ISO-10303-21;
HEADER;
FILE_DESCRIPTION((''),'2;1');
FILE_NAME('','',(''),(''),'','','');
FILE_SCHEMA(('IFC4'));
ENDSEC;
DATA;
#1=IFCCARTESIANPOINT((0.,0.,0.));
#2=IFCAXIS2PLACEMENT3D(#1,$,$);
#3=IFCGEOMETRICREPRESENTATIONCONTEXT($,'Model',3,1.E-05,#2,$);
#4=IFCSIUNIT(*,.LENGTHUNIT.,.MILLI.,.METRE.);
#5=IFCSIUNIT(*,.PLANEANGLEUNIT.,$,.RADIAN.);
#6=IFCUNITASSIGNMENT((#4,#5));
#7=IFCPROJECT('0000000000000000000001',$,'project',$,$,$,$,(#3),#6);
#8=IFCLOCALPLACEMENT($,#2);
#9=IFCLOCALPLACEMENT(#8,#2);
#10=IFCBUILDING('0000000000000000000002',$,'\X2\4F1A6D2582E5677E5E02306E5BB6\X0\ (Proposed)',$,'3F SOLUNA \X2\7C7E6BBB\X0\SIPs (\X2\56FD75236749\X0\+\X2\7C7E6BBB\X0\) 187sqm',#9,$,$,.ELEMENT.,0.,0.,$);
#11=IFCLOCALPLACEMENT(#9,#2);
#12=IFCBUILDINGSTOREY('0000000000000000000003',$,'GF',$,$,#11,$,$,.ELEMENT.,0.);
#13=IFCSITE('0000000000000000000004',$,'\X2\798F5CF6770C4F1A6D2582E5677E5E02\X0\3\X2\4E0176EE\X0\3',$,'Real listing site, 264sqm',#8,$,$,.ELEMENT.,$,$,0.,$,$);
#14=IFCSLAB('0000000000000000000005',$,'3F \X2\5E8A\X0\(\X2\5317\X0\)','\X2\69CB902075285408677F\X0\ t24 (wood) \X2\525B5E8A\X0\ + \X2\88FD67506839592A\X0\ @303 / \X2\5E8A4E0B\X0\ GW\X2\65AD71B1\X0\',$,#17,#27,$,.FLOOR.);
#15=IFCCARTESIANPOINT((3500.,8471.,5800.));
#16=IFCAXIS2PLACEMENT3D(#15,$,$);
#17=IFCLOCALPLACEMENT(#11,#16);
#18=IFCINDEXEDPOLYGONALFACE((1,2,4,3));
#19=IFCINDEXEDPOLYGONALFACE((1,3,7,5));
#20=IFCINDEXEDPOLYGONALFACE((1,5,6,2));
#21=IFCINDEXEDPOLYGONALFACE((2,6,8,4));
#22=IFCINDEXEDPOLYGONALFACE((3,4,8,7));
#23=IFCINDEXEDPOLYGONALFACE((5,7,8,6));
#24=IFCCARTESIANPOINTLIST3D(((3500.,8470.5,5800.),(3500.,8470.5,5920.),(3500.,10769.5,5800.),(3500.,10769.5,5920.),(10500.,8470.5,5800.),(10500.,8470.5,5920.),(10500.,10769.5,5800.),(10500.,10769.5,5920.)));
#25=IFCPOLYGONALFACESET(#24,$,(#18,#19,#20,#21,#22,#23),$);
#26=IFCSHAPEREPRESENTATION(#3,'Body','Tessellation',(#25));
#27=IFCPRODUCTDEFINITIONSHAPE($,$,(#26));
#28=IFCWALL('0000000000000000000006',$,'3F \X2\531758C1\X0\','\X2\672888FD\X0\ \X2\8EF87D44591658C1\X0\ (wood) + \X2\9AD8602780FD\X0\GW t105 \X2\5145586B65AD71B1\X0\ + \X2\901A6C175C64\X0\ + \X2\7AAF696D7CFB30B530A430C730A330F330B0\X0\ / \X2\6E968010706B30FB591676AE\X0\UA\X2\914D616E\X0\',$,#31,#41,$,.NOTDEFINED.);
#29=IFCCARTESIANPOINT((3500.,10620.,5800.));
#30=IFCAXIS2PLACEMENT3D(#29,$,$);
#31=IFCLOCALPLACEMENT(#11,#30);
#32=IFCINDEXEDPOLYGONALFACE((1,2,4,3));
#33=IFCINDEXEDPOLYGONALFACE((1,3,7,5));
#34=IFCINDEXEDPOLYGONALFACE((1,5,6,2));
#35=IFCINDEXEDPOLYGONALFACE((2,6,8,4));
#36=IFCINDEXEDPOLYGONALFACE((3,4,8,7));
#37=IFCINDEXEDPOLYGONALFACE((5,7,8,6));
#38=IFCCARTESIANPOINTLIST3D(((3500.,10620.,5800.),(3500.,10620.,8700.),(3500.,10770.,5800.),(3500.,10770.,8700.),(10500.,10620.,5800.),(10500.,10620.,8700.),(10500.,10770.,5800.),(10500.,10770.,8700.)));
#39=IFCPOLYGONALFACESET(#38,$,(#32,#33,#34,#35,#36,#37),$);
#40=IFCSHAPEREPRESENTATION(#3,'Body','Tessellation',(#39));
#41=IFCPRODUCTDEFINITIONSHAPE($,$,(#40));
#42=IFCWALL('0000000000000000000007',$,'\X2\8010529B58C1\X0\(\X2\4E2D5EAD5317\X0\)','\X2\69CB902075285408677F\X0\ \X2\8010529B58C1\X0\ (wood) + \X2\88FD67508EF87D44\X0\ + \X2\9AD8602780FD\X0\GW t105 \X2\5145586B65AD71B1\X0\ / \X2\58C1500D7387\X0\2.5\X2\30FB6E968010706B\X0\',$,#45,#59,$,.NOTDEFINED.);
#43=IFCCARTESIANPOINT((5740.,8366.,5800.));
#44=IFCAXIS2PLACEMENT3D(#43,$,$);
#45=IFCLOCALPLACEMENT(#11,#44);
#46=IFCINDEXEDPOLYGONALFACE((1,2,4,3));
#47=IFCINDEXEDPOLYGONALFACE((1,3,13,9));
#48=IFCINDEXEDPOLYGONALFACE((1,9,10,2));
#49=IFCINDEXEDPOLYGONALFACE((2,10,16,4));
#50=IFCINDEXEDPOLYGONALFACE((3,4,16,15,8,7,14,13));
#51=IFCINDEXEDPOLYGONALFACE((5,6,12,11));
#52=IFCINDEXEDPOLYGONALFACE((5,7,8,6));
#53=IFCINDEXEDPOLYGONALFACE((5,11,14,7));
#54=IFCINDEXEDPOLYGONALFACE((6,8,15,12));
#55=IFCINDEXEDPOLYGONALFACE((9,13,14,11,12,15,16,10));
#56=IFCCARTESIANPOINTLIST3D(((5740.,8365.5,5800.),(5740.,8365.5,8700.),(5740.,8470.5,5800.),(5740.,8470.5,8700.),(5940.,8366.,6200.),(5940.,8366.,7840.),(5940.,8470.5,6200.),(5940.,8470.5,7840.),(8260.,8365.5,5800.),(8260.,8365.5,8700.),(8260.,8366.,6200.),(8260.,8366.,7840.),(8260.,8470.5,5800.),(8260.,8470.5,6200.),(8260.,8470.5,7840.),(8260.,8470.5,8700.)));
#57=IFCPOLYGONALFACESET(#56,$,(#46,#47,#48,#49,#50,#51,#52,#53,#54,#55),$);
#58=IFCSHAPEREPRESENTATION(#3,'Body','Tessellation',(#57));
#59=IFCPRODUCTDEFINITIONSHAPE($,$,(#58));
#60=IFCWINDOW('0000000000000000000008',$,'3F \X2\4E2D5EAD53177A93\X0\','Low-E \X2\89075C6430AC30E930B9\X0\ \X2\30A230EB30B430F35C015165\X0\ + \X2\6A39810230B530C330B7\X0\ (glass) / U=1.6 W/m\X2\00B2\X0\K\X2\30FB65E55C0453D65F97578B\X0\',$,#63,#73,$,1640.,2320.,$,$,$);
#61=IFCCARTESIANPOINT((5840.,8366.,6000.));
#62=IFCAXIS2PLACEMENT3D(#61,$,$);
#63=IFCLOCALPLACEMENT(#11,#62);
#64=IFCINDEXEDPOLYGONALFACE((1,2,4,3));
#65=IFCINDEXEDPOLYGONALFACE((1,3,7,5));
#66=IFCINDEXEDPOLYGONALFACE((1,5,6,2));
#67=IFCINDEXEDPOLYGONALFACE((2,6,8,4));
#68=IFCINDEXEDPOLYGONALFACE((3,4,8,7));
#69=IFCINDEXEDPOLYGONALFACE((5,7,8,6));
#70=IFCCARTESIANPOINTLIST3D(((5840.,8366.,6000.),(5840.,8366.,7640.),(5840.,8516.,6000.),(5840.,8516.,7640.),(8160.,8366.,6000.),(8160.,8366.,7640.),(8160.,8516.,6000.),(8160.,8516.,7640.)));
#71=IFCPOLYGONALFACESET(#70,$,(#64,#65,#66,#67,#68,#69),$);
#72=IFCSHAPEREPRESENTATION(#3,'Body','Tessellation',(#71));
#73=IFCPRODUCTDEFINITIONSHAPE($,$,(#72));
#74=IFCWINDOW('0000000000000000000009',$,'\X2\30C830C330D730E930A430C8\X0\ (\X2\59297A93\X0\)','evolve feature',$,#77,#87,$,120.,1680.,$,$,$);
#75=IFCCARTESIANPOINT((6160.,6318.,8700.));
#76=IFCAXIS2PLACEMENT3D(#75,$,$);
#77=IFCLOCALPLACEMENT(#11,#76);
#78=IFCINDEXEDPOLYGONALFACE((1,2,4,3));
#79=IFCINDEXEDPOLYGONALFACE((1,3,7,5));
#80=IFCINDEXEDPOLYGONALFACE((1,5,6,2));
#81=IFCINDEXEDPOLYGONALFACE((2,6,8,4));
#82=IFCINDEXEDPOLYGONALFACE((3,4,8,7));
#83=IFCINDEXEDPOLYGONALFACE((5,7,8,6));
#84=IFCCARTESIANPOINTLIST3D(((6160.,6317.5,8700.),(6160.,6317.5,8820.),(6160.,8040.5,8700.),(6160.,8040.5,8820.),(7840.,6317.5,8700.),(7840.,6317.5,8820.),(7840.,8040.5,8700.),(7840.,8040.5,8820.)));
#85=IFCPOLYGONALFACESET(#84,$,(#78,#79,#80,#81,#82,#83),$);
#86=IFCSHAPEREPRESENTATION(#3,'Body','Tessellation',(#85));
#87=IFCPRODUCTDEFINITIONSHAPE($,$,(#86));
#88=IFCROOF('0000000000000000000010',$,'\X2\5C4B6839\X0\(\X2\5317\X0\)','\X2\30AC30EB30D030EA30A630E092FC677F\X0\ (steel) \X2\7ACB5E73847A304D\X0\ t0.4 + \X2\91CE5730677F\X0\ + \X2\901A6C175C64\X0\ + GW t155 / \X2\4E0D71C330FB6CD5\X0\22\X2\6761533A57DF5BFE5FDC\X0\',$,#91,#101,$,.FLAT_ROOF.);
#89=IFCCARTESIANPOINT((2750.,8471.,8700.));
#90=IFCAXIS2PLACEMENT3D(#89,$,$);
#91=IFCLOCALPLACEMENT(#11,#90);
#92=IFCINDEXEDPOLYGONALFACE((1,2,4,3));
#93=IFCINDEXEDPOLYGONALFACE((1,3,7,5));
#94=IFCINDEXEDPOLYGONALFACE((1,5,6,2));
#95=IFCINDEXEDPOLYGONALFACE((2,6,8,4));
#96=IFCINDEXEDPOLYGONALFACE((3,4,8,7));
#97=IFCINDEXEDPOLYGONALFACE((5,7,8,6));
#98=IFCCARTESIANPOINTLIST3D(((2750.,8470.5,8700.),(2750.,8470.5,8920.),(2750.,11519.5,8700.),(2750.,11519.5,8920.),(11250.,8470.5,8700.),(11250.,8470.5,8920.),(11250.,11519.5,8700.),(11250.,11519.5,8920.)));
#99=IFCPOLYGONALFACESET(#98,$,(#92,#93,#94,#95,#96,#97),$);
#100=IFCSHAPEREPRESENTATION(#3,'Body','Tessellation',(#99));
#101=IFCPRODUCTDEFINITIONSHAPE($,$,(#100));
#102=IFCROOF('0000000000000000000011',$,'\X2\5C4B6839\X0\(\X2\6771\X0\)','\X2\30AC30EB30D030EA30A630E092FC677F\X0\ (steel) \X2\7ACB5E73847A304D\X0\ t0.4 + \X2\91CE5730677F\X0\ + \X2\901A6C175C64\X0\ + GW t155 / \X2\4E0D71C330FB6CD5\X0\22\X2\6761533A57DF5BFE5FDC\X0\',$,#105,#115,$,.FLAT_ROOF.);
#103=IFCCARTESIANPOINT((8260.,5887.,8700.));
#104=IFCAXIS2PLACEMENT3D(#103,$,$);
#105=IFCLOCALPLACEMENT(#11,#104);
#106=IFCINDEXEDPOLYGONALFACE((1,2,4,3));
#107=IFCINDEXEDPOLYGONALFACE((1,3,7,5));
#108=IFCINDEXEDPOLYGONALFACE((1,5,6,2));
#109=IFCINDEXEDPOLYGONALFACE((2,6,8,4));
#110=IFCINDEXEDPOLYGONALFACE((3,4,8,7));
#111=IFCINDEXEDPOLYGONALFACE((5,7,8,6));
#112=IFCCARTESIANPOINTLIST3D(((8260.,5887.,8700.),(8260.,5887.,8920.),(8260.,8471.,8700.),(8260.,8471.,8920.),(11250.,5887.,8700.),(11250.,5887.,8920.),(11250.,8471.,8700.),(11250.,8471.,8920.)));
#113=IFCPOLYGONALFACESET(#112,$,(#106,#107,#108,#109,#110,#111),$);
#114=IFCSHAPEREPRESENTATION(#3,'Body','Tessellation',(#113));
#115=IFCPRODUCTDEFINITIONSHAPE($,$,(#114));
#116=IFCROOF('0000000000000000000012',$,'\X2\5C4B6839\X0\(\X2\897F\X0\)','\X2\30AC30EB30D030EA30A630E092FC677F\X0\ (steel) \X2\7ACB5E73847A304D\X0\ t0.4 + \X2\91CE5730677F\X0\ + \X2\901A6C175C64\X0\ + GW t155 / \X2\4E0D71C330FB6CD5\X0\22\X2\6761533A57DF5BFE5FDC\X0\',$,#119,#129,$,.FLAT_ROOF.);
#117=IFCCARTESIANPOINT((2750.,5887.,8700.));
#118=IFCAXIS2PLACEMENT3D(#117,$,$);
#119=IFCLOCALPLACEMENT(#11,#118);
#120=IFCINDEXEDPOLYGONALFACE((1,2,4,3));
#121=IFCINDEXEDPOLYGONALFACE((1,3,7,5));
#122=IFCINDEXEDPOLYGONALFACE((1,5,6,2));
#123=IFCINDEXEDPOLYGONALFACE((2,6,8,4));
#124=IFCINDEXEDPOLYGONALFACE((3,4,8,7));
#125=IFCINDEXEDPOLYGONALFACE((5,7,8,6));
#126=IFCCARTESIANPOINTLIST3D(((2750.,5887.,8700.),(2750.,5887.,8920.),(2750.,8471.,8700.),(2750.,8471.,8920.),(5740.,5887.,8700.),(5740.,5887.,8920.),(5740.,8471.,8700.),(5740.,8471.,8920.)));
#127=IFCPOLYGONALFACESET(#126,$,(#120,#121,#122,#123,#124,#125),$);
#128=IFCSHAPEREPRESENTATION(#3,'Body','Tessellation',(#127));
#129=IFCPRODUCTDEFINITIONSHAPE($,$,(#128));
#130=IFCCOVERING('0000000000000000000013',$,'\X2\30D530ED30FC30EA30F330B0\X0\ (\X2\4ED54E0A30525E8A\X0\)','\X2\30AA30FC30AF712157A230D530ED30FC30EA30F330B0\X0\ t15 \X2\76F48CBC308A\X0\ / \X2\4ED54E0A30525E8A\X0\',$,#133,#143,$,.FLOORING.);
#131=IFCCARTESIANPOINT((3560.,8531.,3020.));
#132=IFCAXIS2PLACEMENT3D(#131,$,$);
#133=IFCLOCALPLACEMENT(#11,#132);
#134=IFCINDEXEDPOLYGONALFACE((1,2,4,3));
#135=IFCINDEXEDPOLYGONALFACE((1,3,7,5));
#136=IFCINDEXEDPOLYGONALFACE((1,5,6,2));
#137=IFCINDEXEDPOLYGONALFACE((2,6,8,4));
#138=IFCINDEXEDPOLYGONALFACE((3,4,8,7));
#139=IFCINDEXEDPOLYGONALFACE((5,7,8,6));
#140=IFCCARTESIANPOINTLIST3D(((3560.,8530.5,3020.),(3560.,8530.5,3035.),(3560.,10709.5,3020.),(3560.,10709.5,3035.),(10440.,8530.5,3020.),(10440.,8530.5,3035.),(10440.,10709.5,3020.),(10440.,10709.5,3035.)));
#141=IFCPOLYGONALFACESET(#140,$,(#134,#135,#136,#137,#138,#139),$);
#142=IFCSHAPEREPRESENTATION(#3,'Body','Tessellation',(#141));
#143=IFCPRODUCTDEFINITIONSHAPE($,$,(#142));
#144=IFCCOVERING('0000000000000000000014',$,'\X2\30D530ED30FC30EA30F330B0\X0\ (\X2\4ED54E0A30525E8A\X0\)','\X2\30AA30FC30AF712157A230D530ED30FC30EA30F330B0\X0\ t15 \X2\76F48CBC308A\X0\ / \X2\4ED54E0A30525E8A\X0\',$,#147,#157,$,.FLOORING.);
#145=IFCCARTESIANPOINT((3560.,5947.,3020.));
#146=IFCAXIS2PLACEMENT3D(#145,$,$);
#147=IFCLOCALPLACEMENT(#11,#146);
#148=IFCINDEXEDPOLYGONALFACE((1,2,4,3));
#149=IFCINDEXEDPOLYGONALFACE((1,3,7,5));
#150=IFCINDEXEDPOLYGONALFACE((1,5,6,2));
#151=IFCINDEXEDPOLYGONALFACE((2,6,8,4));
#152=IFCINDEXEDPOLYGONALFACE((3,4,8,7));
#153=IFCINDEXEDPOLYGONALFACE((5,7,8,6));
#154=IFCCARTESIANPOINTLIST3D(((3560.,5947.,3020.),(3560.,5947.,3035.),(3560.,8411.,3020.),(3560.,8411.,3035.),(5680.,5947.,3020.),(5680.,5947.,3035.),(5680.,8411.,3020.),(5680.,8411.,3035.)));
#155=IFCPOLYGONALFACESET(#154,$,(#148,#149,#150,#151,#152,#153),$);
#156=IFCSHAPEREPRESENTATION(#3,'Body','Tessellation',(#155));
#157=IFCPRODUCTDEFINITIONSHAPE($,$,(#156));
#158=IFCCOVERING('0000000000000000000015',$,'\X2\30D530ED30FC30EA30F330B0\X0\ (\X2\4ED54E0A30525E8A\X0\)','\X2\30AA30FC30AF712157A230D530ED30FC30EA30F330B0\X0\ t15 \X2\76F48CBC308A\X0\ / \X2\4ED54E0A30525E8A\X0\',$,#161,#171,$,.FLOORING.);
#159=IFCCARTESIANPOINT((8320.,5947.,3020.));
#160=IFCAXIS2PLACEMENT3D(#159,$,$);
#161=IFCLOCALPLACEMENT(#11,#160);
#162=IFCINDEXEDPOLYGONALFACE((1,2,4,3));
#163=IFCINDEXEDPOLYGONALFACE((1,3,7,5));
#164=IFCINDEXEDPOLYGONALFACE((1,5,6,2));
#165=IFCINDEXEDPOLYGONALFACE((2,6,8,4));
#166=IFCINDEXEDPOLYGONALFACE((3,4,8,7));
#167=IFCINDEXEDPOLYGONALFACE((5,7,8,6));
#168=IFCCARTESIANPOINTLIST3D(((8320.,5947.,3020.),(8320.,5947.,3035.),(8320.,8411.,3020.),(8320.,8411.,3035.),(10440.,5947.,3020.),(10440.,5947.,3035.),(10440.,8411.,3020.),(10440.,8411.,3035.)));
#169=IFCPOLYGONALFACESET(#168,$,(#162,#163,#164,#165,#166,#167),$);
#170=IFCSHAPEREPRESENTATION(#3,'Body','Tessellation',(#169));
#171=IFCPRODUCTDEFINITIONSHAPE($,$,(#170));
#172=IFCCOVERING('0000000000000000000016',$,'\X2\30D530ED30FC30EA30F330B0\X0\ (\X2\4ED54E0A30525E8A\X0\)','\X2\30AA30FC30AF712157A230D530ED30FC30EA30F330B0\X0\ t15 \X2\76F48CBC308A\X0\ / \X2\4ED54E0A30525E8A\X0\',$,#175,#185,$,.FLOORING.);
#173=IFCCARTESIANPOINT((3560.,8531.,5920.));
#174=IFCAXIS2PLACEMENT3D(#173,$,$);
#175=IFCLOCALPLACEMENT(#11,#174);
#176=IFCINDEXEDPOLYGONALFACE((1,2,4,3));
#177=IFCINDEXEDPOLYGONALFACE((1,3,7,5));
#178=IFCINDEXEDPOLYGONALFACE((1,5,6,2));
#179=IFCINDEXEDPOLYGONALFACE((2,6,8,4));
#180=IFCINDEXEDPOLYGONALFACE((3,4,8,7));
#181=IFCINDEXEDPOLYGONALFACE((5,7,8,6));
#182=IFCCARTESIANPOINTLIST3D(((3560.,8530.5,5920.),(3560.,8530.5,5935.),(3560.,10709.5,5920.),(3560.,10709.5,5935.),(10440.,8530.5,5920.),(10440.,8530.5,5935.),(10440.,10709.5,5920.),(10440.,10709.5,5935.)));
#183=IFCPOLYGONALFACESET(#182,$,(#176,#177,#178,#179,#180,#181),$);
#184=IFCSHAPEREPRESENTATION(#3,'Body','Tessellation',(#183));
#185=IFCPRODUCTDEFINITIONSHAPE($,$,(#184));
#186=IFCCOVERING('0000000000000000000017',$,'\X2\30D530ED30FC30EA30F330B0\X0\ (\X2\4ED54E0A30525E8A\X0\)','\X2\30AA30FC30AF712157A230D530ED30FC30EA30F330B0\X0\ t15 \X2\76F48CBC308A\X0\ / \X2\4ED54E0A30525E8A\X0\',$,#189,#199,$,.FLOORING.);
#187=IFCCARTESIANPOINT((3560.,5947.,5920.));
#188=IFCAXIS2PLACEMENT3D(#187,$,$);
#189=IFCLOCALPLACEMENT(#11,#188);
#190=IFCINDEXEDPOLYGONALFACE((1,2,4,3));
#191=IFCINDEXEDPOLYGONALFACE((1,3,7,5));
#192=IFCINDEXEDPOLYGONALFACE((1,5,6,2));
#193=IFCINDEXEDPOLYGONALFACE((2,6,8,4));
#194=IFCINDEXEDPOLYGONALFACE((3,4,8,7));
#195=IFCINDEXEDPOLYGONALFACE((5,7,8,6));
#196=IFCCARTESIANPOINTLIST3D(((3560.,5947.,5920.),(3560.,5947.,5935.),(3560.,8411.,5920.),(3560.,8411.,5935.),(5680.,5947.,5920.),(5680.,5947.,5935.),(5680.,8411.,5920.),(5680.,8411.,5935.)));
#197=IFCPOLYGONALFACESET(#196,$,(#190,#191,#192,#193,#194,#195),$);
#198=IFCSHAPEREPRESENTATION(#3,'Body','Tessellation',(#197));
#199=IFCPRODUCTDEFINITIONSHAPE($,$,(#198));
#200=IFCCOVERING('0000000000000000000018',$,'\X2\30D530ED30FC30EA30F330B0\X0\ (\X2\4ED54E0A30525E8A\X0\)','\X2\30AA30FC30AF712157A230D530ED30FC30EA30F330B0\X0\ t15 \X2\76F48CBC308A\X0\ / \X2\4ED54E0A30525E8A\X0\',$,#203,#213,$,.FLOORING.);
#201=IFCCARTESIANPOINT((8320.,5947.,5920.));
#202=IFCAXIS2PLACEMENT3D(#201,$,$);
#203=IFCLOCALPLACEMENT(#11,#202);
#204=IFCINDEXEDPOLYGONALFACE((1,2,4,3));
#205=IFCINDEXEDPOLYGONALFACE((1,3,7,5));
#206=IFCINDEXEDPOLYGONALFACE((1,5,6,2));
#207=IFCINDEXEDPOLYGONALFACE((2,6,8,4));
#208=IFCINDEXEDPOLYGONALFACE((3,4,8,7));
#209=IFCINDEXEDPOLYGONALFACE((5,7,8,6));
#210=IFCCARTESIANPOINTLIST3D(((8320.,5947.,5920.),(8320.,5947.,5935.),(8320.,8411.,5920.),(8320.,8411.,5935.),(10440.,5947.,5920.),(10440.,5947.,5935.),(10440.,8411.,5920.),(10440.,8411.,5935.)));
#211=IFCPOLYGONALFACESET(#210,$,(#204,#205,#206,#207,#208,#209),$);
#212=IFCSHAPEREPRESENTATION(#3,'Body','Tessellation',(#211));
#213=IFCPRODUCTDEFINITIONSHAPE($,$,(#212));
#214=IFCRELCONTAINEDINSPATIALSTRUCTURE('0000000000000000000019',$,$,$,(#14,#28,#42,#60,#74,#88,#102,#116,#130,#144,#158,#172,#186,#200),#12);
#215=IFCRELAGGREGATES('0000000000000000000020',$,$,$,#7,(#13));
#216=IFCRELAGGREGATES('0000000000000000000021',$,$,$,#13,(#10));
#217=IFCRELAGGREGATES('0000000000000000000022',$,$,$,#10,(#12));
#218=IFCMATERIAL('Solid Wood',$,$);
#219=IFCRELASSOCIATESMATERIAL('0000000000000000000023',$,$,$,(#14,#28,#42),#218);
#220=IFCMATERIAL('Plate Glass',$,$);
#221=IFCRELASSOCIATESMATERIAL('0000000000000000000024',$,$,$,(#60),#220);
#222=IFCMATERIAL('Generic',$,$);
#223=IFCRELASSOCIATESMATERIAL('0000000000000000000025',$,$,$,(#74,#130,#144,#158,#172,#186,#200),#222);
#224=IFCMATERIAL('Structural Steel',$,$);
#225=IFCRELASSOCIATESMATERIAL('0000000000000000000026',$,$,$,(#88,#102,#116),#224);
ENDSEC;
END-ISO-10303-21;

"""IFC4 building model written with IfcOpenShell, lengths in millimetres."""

from ifc_helpers import new_model, si_unit, frame, frame_2d, origin, place, context, project, spatial, rectangle, extrude, material, element, fill, save


model = new_model("IFC4")

# Units and contexts
model_context = context("Model", 3, precision=1e-05, world=origin())
ifc_project = project(units=[si_unit("LENGTHUNIT", "METRE", prefix="MILLI"), si_unit("PLANEANGLEUNIT", "RADIAN")], contexts=[model_context])

# Site, building, storey
site_placement = place(None, origin())
site = spatial("IfcSite", under=ifc_project, at=site_placement, Name="福島県会津若松市3丁目3", ObjectType="Real listing site, 264sqm", CompositionType="ELEMENT", RefElevation=0.0)
building_placement = place(site_placement, origin())
building = spatial("IfcBuilding", under=site, at=building_placement, Name="会津若松市の家 (Proposed)", ObjectType="3F SOLUNA 籾殻SIPs (国産杉+籾殻) 187sqm", CompositionType="ELEMENT", ElevationOfRefHeight=0.0, ElevationOfTerrain=0.0)
storey_placement = place(building_placement, origin())
storey = spatial("IfcBuildingStorey", under=building, at=storey_placement, Name="GF", CompositionType="ELEMENT", Elevation=0.0)

# Slab
ifc_material_1 = material(Name="Solid Wood")
slab_placement = place(storey_placement, frame((3500.0, 8471.0, 5800.0)))
element("IfcSlab", 1, at=slab_placement, inside=storey, material=ifc_material_1, Name="3F 床(北)", Description="構造用合板 t24 (wood) 剛床 + 製材根太 @303 / 床下 GW断熱", PredefinedType="FLOOR", context=model_context, shape_type="SweptSolid", body=[
    extrude(rectangle(XDim=7000.0, YDim=2299.0, at=frame_2d((3500.0, 1149.0))), frame((3500.0, 8471.0, 5800.0)), (0.0, 0.0, 1.0), 120.0),
])

# Wall
wall_1_placement = place(storey_placement, frame((3500.0, 10620.0, 5800.0)))
element("IfcWall", 2, at=wall_1_placement, inside=storey, material=ifc_material_1, Name="3F 北壁", Description="木製 軸組外壁 (wood) + 高性能GW t105 充填断熱 + 通気層 + 窯業系サイディング / 準耐火・外皮UA配慮", PredefinedType="NOTDEFINED", context=model_context, shape_type="SweptSolid", body=[
    extrude(rectangle(XDim=7000.0, YDim=150.0, at=frame_2d((3500.0, 75.0))), frame((3500.0, 10620.0, 5800.0)), (0.0, 0.0, 1.0), 2900.0),
])

# Wall, opening, window
wall_2_placement = place(storey_placement, frame((5740.0, 8366.0, 5800.0)))
wall_2 = element("IfcWall", 3, at=wall_2_placement, inside=storey, material=ifc_material_1, Name="耐力壁(中庭北)", Description="構造用合板 耐力壁 (wood) + 製材軸組 + 高性能GW t105 充填断熱 / 壁倍率2.5・準耐火", PredefinedType="NOTDEFINED", context=model_context, shape_type="SweptSolid", body=[
    extrude(rectangle(XDim=2520.0, YDim=105.0, at=frame_2d((1260.0, 52.0))), frame((5740.0, 8366.0, 5800.0)), (0.0, 0.0, 1.0), 2900.0),
])
opening_placement = place(storey_placement, frame((5840.0, 8366.0, 6000.0)))
opening = element("IfcOpeningElement", 4, at=opening_placement, cuts=wall_2, PredefinedType="NOTDEFINED", context=model_context, shape_type="SweptSolid", body=[
    extrude(rectangle(XDim=2320.0, YDim=150.0, at=frame_2d((1160.0, 75.0))), frame((5840.0, 8366.0, 6000.0)), (0.0, 0.0, 1.0), 1640.0),
])
ifc_material_2 = material(Name="Plate Glass")
window_1_placement = place(storey_placement, frame((5840.0, 8366.0, 6000.0)))
window_1 = element("IfcWindow", 5, at=window_1_placement, inside=storey, material=ifc_material_2, Name="3F 中庭北窓", Description="Low-E 複層ガラス アルゴン封入 + 樹脂サッシ (glass) / U=1.6 W/m²K・日射取得型", OverallHeight=1640.0, OverallWidth=2320.0, context=model_context, shape_type="SweptSolid", body=[
    extrude(rectangle(XDim=2320.0, YDim=150.0, at=frame_2d((1160.0, 75.0))), frame((5840.0, 8366.0, 6000.0)), (0.0, 0.0, 1.0), 1640.0),
])
fill(opening, window_1)

# Window
ifc_material_3 = material(Name="Generic")
window_2_placement = place(storey_placement, frame((6160.0, 6318.0, 8700.0)))
element("IfcWindow", 6, at=window_2_placement, inside=storey, material=ifc_material_3, Name="トップライト (天窓)", Description="evolve feature", OverallHeight=120.0, OverallWidth=1680.0, context=model_context, shape_type="SweptSolid", body=[
    extrude(rectangle(XDim=1680.0, YDim=1723.0, at=frame_2d((840.0, 861.0))), frame((6160.0, 6318.0, 8700.0)), (0.0, 0.0, 1.0), 120.0),
])

# Roofs
ifc_material_4 = material(Name="Structural Steel")
roof_1_placement = place(storey_placement, frame((2750.0, 8471.0, 8700.0)))
element("IfcRoof", 7, at=roof_1_placement, inside=storey, material=ifc_material_4, Name="屋根(北)", Description="ガルバリウム鋼板 (steel) 立平葺き t0.4 + 野地板 + 通気層 + GW t155 / 不燃・法22条区域対応", PredefinedType="FLAT_ROOF", context=model_context, shape_type="SweptSolid", body=[
    extrude(rectangle(XDim=8500.0, YDim=3049.0, at=frame_2d((4250.0, 1524.0))), frame((2750.0, 8471.0, 8700.0)), (0.0, 0.0, 1.0), 220.0),
])
roof_2_placement = place(storey_placement, frame((8260.0, 5887.0, 8700.0)))
element("IfcRoof", 8, at=roof_2_placement, inside=storey, material=ifc_material_4, Name="屋根(東)", Description="ガルバリウム鋼板 (steel) 立平葺き t0.4 + 野地板 + 通気層 + GW t155 / 不燃・法22条区域対応", PredefinedType="FLAT_ROOF", context=model_context, shape_type="SweptSolid", body=[
    extrude(rectangle(XDim=2990.0, YDim=2584.0, at=frame_2d((1495.0, 1292.0))), frame((8260.0, 5887.0, 8700.0)), (0.0, 0.0, 1.0), 220.0),
])
roof_3_placement = place(storey_placement, frame((2750.0, 5887.0, 8700.0)))
element("IfcRoof", 9, at=roof_3_placement, inside=storey, material=ifc_material_4, Name="屋根(西)", Description="ガルバリウム鋼板 (steel) 立平葺き t0.4 + 野地板 + 通気層 + GW t155 / 不燃・法22条区域対応", PredefinedType="FLAT_ROOF", context=model_context, shape_type="SweptSolid", body=[
    extrude(rectangle(XDim=2990.0, YDim=2584.0, at=frame_2d((1495.0, 1292.0))), frame((2750.0, 5887.0, 8700.0)), (0.0, 0.0, 1.0), 220.0),
])

# Coverings
covering_1_placement = place(storey_placement, frame((3560.0, 8531.0, 3020.0)))
element("IfcCovering", 10, at=covering_1_placement, inside=storey, material=ifc_material_3, Name="フローリング (仕上げ床)", Description="オーク無垢フローリング t15 直貼り / 仕上げ床", PredefinedType="FLOORING", context=model_context, shape_type="SweptSolid", body=[
    extrude(rectangle(XDim=6880.0, YDim=2179.0, at=frame_2d((3440.0, 1089.0))), frame((3560.0, 8531.0, 3020.0)), (0.0, 0.0, 1.0), 15.0),
])
covering_2_placement = place(storey_placement, frame((3560.0, 5947.0, 3020.0)))
element("IfcCovering", 11, at=covering_2_placement, inside=storey, material=ifc_material_3, Name="フローリング (仕上げ床)", Description="オーク無垢フローリング t15 直貼り / 仕上げ床", PredefinedType="FLOORING", context=model_context, shape_type="SweptSolid", body=[
    extrude(rectangle(XDim=2120.0, YDim=2464.0, at=frame_2d((1060.0, 1232.0))), frame((3560.0, 5947.0, 3020.0)), (0.0, 0.0, 1.0), 15.0),
])
covering_3_placement = place(storey_placement, frame((8320.0, 5947.0, 3020.0)))
element("IfcCovering", 12, at=covering_3_placement, inside=storey, material=ifc_material_3, Name="フローリング (仕上げ床)", Description="オーク無垢フローリング t15 直貼り / 仕上げ床", PredefinedType="FLOORING", context=model_context, shape_type="SweptSolid", body=[
    extrude(rectangle(XDim=2120.0, YDim=2464.0, at=frame_2d((1060.0, 1232.0))), frame((8320.0, 5947.0, 3020.0)), (0.0, 0.0, 1.0), 15.0),
])
covering_4_placement = place(storey_placement, frame((3560.0, 8531.0, 5920.0)))
element("IfcCovering", 13, at=covering_4_placement, inside=storey, material=ifc_material_3, Name="フローリング (仕上げ床)", Description="オーク無垢フローリング t15 直貼り / 仕上げ床", PredefinedType="FLOORING", context=model_context, shape_type="SweptSolid", body=[
    extrude(rectangle(XDim=6880.0, YDim=2179.0, at=frame_2d((3440.0, 1089.0))), frame((3560.0, 8531.0, 5920.0)), (0.0, 0.0, 1.0), 15.0),
])
covering_5_placement = place(storey_placement, frame((3560.0, 5947.0, 5920.0)))
element("IfcCovering", 14, at=covering_5_placement, inside=storey, material=ifc_material_3, Name="フローリング (仕上げ床)", Description="オーク無垢フローリング t15 直貼り / 仕上げ床", PredefinedType="FLOORING", context=model_context, shape_type="SweptSolid", body=[
    extrude(rectangle(XDim=2120.0, YDim=2464.0, at=frame_2d((1060.0, 1232.0))), frame((3560.0, 5947.0, 5920.0)), (0.0, 0.0, 1.0), 15.0),
])
covering_6_placement = place(storey_placement, frame((8320.0, 5947.0, 5920.0)))
element("IfcCovering", 15, at=covering_6_placement, inside=storey, material=ifc_material_3, Name="フローリング (仕上げ床)", Description="オーク無垢フローリング t15 直貼り / 仕上げ床", PredefinedType="FLOORING", context=model_context, shape_type="SweptSolid", body=[
    extrude(rectangle(XDim=2120.0, YDim=2464.0, at=frame_2d((1060.0, 1232.0))), frame((8320.0, 5947.0, 5920.0)), (0.0, 0.0, 1.0), 15.0),
])

save(model, "model.ifc")
